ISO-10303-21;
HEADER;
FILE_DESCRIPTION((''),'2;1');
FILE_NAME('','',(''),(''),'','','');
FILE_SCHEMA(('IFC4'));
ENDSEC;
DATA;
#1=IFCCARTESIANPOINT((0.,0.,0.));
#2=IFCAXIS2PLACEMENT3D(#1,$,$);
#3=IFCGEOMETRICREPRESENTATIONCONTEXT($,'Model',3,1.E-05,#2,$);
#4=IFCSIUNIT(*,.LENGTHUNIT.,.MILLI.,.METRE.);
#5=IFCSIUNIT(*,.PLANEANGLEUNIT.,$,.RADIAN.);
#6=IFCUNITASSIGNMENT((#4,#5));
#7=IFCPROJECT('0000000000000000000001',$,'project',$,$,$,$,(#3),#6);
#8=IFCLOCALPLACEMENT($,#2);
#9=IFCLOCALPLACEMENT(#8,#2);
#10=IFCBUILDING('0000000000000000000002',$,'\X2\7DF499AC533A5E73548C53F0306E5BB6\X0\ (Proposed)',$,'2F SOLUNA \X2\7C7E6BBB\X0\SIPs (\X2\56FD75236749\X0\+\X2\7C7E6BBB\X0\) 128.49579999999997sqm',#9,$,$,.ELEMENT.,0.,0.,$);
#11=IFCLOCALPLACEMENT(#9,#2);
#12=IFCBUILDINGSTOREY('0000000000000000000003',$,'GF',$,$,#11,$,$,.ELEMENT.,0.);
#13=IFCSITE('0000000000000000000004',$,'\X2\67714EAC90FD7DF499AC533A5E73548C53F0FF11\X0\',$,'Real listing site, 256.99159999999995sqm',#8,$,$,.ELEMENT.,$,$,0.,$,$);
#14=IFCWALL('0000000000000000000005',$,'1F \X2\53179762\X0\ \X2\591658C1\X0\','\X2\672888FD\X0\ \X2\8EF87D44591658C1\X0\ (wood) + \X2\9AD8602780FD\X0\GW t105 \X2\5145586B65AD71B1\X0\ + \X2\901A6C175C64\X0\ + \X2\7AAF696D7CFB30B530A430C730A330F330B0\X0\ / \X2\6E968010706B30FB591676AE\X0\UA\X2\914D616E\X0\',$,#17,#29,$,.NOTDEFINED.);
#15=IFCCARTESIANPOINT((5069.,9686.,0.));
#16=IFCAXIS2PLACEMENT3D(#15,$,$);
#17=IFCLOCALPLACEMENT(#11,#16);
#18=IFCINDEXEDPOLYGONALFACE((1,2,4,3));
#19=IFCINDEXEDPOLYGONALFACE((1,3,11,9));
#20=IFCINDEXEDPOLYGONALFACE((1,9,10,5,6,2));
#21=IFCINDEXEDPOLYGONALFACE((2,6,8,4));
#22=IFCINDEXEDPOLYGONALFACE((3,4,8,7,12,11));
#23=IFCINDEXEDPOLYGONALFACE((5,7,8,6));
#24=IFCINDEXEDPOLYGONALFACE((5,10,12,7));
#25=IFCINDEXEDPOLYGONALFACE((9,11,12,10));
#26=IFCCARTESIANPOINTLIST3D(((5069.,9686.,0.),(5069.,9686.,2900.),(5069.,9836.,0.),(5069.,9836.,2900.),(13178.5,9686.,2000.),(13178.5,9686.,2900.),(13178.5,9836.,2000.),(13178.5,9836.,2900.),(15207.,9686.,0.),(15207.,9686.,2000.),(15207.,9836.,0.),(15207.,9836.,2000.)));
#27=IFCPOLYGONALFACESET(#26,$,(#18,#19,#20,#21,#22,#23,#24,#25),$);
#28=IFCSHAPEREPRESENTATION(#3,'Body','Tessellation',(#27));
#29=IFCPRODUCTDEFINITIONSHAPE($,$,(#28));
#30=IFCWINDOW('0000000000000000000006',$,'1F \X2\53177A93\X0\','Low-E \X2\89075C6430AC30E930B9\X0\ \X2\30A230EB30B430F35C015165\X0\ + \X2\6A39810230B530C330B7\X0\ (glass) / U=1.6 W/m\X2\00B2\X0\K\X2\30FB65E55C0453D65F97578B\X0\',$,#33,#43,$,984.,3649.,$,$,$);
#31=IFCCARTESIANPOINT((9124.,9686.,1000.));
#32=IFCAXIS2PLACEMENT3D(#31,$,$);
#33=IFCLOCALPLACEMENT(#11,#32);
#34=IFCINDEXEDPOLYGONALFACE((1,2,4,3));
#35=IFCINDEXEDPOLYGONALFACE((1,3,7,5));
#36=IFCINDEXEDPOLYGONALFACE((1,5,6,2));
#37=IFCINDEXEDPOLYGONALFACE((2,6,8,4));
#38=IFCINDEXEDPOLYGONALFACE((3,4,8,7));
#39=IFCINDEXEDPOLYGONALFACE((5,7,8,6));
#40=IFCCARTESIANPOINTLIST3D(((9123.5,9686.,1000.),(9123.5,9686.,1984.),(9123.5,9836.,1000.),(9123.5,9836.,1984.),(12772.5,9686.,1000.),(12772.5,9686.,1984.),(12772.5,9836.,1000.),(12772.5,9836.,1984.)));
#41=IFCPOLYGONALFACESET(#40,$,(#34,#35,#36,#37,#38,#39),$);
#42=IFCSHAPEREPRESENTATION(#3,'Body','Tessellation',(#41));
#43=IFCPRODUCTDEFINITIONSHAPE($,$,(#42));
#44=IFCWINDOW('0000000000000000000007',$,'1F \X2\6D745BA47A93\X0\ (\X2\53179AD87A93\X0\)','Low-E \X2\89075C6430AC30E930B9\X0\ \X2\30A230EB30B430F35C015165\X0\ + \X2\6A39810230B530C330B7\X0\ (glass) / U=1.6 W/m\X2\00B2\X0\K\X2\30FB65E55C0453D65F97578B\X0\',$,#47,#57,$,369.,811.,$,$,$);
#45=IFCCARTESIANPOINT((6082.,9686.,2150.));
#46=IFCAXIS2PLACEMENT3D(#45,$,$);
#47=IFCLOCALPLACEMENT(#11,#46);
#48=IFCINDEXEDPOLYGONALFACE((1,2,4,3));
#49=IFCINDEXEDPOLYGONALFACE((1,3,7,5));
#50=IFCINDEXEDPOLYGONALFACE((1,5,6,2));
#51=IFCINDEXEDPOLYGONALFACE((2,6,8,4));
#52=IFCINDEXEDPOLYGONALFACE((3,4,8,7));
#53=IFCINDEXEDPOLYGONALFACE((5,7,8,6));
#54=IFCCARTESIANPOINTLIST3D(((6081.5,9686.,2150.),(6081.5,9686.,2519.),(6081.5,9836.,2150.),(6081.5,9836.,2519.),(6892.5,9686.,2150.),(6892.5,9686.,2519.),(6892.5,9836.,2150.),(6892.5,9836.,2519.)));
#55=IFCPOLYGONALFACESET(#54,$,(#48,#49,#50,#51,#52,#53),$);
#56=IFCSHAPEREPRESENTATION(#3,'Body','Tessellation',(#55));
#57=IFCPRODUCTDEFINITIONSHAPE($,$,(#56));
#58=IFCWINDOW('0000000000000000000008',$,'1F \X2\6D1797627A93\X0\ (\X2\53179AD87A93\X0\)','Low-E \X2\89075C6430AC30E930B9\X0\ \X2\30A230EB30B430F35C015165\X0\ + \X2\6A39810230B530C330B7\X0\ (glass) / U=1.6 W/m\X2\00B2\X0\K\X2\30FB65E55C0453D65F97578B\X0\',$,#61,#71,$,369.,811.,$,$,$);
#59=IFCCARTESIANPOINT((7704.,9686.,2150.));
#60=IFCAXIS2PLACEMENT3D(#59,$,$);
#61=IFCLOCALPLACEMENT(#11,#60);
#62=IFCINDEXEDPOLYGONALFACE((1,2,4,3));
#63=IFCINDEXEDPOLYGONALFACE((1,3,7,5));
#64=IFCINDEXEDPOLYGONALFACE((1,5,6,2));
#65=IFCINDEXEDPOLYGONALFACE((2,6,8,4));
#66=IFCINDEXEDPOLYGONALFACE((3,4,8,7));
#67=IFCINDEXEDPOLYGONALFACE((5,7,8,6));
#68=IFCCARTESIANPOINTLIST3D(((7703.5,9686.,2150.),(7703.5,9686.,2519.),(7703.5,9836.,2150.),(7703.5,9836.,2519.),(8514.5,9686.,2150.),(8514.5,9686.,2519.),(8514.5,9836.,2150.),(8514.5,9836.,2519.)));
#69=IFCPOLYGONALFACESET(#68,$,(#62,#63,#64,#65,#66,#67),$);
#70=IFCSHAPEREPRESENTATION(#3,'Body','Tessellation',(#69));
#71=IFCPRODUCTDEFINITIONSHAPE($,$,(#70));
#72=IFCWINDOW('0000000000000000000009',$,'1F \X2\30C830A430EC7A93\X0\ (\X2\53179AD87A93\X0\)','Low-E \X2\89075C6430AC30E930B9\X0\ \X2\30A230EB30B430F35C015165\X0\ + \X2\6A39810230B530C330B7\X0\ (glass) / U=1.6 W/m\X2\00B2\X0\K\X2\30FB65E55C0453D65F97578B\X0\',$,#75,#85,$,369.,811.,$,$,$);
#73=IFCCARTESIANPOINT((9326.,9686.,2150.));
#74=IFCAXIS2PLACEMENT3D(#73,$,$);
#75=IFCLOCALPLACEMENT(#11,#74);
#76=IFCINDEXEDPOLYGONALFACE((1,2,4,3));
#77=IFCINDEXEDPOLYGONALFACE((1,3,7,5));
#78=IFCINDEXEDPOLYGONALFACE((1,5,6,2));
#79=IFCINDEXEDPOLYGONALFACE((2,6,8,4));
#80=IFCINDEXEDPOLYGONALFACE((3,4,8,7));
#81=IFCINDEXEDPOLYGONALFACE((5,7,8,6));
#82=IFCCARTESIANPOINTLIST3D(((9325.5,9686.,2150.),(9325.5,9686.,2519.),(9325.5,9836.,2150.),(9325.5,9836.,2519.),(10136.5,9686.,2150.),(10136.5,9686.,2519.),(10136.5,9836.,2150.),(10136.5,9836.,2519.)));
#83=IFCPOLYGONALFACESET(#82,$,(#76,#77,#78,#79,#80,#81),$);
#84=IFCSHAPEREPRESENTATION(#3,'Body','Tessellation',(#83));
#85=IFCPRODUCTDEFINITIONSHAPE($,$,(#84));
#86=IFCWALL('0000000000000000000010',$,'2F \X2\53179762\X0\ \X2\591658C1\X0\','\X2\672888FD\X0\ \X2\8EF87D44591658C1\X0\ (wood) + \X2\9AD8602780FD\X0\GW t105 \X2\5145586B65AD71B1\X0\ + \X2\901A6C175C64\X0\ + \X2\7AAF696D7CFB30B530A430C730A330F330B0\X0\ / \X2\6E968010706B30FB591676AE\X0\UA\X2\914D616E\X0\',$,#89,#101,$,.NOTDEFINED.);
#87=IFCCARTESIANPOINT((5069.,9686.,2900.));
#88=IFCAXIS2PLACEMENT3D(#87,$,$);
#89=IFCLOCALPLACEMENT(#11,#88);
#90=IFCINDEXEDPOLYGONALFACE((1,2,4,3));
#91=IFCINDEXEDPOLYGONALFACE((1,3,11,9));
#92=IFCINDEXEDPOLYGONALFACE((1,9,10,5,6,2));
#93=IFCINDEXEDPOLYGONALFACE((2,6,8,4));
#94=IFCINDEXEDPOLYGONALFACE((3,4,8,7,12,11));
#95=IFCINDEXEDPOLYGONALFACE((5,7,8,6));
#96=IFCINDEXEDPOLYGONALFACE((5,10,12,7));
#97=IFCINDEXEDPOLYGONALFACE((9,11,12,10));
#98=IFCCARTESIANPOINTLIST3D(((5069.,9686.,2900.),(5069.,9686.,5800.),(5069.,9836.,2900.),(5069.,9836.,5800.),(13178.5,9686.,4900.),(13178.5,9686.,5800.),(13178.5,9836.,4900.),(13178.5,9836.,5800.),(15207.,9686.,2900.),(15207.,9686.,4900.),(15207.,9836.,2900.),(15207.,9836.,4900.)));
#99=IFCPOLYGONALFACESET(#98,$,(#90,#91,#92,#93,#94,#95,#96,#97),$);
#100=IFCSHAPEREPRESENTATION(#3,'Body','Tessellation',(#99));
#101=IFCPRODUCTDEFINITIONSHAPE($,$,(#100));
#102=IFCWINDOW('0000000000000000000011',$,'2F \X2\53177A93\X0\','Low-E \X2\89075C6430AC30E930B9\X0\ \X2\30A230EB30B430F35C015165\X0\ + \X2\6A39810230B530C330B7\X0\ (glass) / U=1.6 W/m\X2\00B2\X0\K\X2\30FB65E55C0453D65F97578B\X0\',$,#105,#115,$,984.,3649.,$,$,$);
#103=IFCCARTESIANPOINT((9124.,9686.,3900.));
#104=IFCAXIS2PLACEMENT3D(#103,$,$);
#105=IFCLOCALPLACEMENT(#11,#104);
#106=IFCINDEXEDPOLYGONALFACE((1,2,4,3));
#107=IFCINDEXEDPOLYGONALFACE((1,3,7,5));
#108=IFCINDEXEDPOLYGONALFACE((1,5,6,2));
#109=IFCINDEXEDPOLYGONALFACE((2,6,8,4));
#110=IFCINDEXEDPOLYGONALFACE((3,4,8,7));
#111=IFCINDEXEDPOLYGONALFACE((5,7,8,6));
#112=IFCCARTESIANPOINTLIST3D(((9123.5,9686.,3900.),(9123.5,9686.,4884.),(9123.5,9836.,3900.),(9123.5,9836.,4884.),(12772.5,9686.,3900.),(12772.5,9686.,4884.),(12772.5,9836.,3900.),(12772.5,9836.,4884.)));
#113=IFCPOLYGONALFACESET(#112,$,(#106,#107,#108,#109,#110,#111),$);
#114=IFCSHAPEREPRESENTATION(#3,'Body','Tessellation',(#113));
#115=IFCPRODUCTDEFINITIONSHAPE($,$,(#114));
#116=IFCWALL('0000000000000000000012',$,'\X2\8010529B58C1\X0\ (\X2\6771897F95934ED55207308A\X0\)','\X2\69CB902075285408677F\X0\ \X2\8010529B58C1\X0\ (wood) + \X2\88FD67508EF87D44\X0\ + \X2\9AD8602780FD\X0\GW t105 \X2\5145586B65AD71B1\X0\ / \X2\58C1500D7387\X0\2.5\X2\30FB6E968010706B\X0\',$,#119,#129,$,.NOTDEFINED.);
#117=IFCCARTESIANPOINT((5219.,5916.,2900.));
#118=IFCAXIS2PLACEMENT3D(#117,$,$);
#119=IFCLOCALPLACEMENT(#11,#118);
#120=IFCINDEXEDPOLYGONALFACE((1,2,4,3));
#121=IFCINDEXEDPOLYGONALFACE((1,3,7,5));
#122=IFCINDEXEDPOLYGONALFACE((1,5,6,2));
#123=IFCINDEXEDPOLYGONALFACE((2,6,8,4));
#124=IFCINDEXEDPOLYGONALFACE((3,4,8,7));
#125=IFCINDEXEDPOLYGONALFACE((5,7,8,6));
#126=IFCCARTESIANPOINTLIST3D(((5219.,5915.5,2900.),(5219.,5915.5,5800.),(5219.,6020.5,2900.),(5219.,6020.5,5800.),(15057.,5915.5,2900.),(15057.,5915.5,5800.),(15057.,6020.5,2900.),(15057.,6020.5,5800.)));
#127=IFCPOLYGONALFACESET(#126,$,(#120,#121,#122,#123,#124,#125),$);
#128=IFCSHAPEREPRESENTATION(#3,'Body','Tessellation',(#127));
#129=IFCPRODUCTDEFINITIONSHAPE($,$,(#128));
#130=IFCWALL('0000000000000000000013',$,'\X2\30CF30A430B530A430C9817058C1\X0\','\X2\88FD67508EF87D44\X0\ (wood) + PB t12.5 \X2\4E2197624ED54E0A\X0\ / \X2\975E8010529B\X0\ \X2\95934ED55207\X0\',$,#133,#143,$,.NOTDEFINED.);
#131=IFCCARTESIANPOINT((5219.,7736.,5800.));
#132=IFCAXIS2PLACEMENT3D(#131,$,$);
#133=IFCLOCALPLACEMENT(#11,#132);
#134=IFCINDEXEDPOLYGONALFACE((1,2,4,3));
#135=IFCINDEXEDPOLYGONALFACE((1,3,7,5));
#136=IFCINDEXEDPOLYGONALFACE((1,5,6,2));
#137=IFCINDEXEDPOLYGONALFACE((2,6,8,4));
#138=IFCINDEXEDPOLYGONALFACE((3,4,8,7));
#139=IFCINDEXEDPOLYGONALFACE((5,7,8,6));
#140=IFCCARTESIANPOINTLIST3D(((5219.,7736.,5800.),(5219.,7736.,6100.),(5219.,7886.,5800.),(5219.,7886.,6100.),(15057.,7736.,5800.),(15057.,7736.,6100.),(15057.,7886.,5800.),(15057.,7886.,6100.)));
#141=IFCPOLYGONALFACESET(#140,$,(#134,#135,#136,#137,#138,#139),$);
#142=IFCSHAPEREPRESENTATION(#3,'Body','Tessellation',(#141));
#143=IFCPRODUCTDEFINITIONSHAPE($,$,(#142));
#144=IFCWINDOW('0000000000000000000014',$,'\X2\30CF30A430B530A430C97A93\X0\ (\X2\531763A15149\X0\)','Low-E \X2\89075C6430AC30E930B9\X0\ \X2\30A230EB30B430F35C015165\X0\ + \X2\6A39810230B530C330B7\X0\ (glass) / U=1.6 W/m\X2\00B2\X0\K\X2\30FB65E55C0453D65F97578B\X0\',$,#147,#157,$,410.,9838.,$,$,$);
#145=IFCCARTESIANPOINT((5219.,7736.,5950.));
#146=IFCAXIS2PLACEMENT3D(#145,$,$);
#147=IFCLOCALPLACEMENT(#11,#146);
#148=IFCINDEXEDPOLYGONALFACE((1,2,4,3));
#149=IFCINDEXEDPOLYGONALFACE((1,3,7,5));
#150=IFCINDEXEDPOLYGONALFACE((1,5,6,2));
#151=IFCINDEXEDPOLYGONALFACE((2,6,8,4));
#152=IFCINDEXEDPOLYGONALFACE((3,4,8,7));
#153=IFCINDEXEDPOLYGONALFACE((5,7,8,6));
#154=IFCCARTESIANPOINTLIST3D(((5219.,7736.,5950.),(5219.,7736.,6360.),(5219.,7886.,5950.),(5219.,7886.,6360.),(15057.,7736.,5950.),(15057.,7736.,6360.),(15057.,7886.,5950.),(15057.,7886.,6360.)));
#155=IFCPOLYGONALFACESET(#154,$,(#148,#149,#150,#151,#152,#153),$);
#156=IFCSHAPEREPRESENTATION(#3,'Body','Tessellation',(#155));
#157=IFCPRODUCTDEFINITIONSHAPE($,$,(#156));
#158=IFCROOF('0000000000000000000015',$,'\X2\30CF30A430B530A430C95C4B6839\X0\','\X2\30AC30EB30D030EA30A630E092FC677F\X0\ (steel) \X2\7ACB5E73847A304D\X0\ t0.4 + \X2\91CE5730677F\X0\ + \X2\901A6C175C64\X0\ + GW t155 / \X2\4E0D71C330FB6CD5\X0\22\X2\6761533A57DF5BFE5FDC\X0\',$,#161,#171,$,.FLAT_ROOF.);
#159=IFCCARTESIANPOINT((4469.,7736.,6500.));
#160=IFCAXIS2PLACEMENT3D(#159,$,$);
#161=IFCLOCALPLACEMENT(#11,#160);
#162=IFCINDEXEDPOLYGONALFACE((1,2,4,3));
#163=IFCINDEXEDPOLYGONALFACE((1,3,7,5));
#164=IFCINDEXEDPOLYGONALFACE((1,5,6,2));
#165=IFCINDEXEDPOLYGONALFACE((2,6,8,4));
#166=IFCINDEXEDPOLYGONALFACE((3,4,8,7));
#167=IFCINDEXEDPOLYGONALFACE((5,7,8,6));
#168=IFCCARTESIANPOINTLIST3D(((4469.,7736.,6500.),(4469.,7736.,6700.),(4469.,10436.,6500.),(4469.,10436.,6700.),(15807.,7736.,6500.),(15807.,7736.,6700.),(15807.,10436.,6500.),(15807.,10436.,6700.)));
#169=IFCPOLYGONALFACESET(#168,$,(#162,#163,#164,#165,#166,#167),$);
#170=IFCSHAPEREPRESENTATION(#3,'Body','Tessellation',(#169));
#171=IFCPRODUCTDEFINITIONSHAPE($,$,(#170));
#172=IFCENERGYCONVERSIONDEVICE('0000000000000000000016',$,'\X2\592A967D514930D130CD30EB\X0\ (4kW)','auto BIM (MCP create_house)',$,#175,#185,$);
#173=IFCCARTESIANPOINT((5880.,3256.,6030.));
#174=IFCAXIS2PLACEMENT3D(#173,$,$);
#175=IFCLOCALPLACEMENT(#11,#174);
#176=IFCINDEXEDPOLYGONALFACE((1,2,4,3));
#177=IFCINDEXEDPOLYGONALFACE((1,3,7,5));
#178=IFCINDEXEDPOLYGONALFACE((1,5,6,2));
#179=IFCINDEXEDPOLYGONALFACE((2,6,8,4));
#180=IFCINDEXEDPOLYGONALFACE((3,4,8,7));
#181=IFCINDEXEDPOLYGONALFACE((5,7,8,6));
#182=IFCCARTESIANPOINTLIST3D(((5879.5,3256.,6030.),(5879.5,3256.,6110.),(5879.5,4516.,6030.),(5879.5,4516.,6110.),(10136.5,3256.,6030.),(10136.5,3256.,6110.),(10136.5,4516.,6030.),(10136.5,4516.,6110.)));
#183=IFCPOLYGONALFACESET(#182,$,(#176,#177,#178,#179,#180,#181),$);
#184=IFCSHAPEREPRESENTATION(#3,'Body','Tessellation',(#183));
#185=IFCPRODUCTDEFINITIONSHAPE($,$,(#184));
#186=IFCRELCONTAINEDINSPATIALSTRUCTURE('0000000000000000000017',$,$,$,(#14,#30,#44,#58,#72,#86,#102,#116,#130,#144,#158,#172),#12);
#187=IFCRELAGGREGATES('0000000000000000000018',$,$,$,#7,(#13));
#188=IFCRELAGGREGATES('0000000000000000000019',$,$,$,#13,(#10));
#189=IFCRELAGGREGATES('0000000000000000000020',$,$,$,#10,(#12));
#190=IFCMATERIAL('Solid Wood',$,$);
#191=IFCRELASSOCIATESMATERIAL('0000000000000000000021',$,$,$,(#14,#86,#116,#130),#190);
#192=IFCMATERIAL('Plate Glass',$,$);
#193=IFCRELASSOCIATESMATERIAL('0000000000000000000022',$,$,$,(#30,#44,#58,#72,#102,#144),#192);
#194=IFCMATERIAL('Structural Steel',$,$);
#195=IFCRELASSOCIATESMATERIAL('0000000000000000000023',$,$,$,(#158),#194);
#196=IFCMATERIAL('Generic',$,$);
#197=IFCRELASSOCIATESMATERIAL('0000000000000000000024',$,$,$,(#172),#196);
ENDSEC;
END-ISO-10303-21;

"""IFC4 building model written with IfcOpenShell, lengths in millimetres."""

from ifc_helpers import new_model, si_unit, frame, frame_2d, origin, place, context, project, spatial, rectangle, extrude, material, element, fill, save


model = new_model("IFC4")

# Units and contexts
model_context = context("Model", 3, precision=1e-05, world=origin())
ifc_project = project(units=[si_unit("LENGTHUNIT", "METRE", prefix="MILLI"), si_unit("PLANEANGLEUNIT", "RADIAN")], contexts=[model_context])

# Site, building, storey
site_placement = place(None, origin())
site = spatial("IfcSite", under=ifc_project, at=site_placement, Name="東京都練馬区平和台１", ObjectType="Real listing site, 256.99159999999995sqm", CompositionType="ELEMENT", RefElevation=0.0)
building_placement = place(site_placement, origin())
building = spatial("IfcBuilding", under=site, at=building_placement, Name="練馬区平和台の家 (Proposed)", ObjectType="2F SOLUNA 籾殻SIPs (国産杉+籾殻) 128.49579999999997sqm", CompositionType="ELEMENT", ElevationOfRefHeight=0.0, ElevationOfTerrain=0.0)
storey_placement = place(building_placement, origin())
storey = spatial("IfcBuildingStorey", under=building, at=storey_placement, Name="GF", CompositionType="ELEMENT", Elevation=0.0)

# Wall, openings, windows
ifc_material_1 = material(Name="Solid Wood")
wall_1_placement = place(storey_placement, frame((5069.0, 9686.0, 0.0)))
wall_1 = element("IfcWall", 1, at=wall_1_placement, inside=storey, material=ifc_material_1, Name="1F 北面 外壁", Description="木製 軸組外壁 (wood) + 高性能GW t105 充填断熱 + 通気層 + 窯業系サイディング / 準耐火・外皮UA配慮", PredefinedType="NOTDEFINED", context=model_context, shape_type="SweptSolid", body=[
    extrude(rectangle(XDim=10138.0, YDim=150.0, at=frame_2d((5069.0, 75.0))), frame((5069.0, 9686.0, 0.0)), (0.0, 0.0, 1.0), 2900.0),
])
opening_1_placement = place(storey_placement, frame((9124.0, 9686.0, 1000.0)))
opening_1 = element("IfcOpeningElement", 2, at=opening_1_placement, cuts=wall_1, PredefinedType="NOTDEFINED", context=model_context, shape_type="SweptSolid", body=[
    extrude(rectangle(XDim=3649.0, YDim=150.0, at=frame_2d((1824.0, 75.0))), frame((9124.0, 9686.0, 1000.0)), (0.0, 0.0, 1.0), 984.0),
])
opening_2_placement = place(storey_placement, frame((6082.0, 9686.0, 2150.0)))
opening_2 = element("IfcOpeningElement", 3, at=opening_2_placement, cuts=wall_1, PredefinedType="NOTDEFINED", context=model_context, shape_type="SweptSolid", body=[
    extrude(rectangle(XDim=811.0, YDim=150.0, at=frame_2d((405.0, 75.0))), frame((6082.0, 9686.0, 2150.0)), (0.0, 0.0, 1.0), 369.0),
])
opening_3_placement = place(storey_placement, frame((7704.0, 9686.0, 2150.0)))
opening_3 = element("IfcOpeningElement", 4, at=opening_3_placement, cuts=wall_1, PredefinedType="NOTDEFINED", context=model_context, shape_type="SweptSolid", body=[
    extrude(rectangle(XDim=811.0, YDim=150.0, at=frame_2d((405.0, 75.0))), frame((7704.0, 9686.0, 2150.0)), (0.0, 0.0, 1.0), 369.0),
])
opening_4_placement = place(storey_placement, frame((9326.0, 9686.0, 2150.0)))
opening_4 = element("IfcOpeningElement", 5, at=opening_4_placement, cuts=wall_1, PredefinedType="NOTDEFINED", context=model_context, shape_type="SweptSolid", body=[
    extrude(rectangle(XDim=811.0, YDim=150.0, at=frame_2d((405.0, 75.0))), frame((9326.0, 9686.0, 2150.0)), (0.0, 0.0, 1.0), 369.0),
])
ifc_material_2 = material(Name="Plate Glass")
window_1_placement = place(storey_placement, frame((9124.0, 9686.0, 1000.0)))
window_1 = element("IfcWindow", 6, at=window_1_placement, inside=storey, material=ifc_material_2, Name="1F 北窓", Description="Low-E 複層ガラス アルゴン封入 + 樹脂サッシ (glass) / U=1.6 W/m²K・日射取得型", OverallHeight=984.0, OverallWidth=3649.0, context=model_context, shape_type="SweptSolid", body=[
    extrude(rectangle(XDim=3649.0, YDim=150.0, at=frame_2d((1824.0, 75.0))), frame((9124.0, 9686.0, 1000.0)), (0.0, 0.0, 1.0), 984.0),
])
fill(opening_1, window_1)
window_2_placement = place(storey_placement, frame((6082.0, 9686.0, 2150.0)))
window_2 = element("IfcWindow", 7, at=window_2_placement, inside=storey, material=ifc_material_2, Name="1F 浴室窓 (北高窓)", Description="Low-E 複層ガラス アルゴン封入 + 樹脂サッシ (glass) / U=1.6 W/m²K・日射取得型", OverallHeight=369.0, OverallWidth=811.0, context=model_context, shape_type="SweptSolid", body=[
    extrude(rectangle(XDim=811.0, YDim=150.0, at=frame_2d((405.0, 75.0))), frame((6082.0, 9686.0, 2150.0)), (0.0, 0.0, 1.0), 369.0),
])
fill(opening_2, window_2)
window_3_placement = place(storey_placement, frame((7704.0, 9686.0, 2150.0)))
window_3 = element("IfcWindow", 8, at=window_3_placement, inside=storey, material=ifc_material_2, Name="1F 洗面窓 (北高窓)", Description="Low-E 複層ガラス アルゴン封入 + 樹脂サッシ (glass) / U=1.6 W/m²K・日射取得型", OverallHeight=369.0, OverallWidth=811.0, context=model_context, shape_type="SweptSolid", body=[
    extrude(rectangle(XDim=811.0, YDim=150.0, at=frame_2d((405.0, 75.0))), frame((7704.0, 9686.0, 2150.0)), (0.0, 0.0, 1.0), 369.0),
])
fill(opening_3, window_3)
window_4_placement = place(storey_placement, frame((9326.0, 9686.0, 2150.0)))
window_4 = element("IfcWindow", 9, at=window_4_placement, inside=storey, material=ifc_material_2, Name="1F トイレ窓 (北高窓)", Description="Low-E 複層ガラス アルゴン封入 + 樹脂サッシ (glass) / U=1.6 W/m²K・日射取得型", OverallHeight=369.0, OverallWidth=811.0, context=model_context, shape_type="SweptSolid", body=[
    extrude(rectangle(XDim=811.0, YDim=150.0, at=frame_2d((405.0, 75.0))), frame((9326.0, 9686.0, 2150.0)), (0.0, 0.0, 1.0), 369.0),
])
fill(opening_4, window_4)

# Wall, opening, window
wall_2_placement = place(storey_placement, frame((5069.0, 9686.0, 2900.0)))
wall_2 = element("IfcWall", 10, at=wall_2_placement, inside=storey, material=ifc_material_1, Name="2F 北面 外壁", Description="木製 軸組外壁 (wood) + 高性能GW t105 充填断熱 + 通気層 + 窯業系サイディング / 準耐火・外皮UA配慮", PredefinedType="NOTDEFINED", context=model_context, shape_type="SweptSolid", body=[
    extrude(rectangle(XDim=10138.0, YDim=150.0, at=frame_2d((5069.0, 75.0))), frame((5069.0, 9686.0, 2900.0)), (0.0, 0.0, 1.0), 2900.0),
])
opening_5_placement = place(storey_placement, frame((9124.0, 9686.0, 3900.0)))
opening_5 = element("IfcOpeningElement", 11, at=opening_5_placement, cuts=wall_2, PredefinedType="NOTDEFINED", context=model_context, shape_type="SweptSolid", body=[
    extrude(rectangle(XDim=3649.0, YDim=150.0, at=frame_2d((1824.0, 75.0))), frame((9124.0, 9686.0, 3900.0)), (0.0, 0.0, 1.0), 984.0),
])
window_5_placement = place(storey_placement, frame((9124.0, 9686.0, 3900.0)))
window_5 = element("IfcWindow", 12, at=window_5_placement, inside=storey, material=ifc_material_2, Name="2F 北窓", Description="Low-E 複層ガラス アルゴン封入 + 樹脂サッシ (glass) / U=1.6 W/m²K・日射取得型", OverallHeight=984.0, OverallWidth=3649.0, context=model_context, shape_type="SweptSolid", body=[
    extrude(rectangle(XDim=3649.0, YDim=150.0, at=frame_2d((1824.0, 75.0))), frame((9124.0, 9686.0, 3900.0)), (0.0, 0.0, 1.0), 984.0),
])
fill(opening_5, window_5)

# Wall
wall_3_placement = place(storey_placement, frame((5219.0, 5916.0, 2900.0)))
element("IfcWall", 13, at=wall_3_placement, inside=storey, material=ifc_material_1, Name="耐力壁 (東西間仕切り)", Description="構造用合板 耐力壁 (wood) + 製材軸組 + 高性能GW t105 充填断熱 / 壁倍率2.5・準耐火", PredefinedType="NOTDEFINED", context=model_context, shape_type="SweptSolid", body=[
    extrude(rectangle(XDim=9838.0, YDim=105.0, at=frame_2d((4919.0, 52.0))), frame((5219.0, 5916.0, 2900.0)), (0.0, 0.0, 1.0), 2900.0),
])

# Wall, opening, window
wall_4_placement = place(storey_placement, frame((5219.0, 7736.0, 5800.0)))
wall_4 = element("IfcWall", 14, at=wall_4_placement, inside=storey, material=ifc_material_1, Name="ハイサイド腰壁", Description="製材軸組 (wood) + PB t12.5 両面仕上 / 非耐力 間仕切", PredefinedType="NOTDEFINED", context=model_context, shape_type="SweptSolid", body=[
    extrude(rectangle(XDim=9838.0, YDim=150.0, at=frame_2d((4919.0, 75.0))), frame((5219.0, 7736.0, 5800.0)), (0.0, 0.0, 1.0), 700.0),
])
opening_6_placement = place(storey_placement, frame((5219.0, 7736.0, 5950.0)))
opening_6 = element("IfcOpeningElement", 15, at=opening_6_placement, cuts=wall_4, PredefinedType="NOTDEFINED", context=model_context, shape_type="SweptSolid", body=[
    extrude(rectangle(XDim=9838.0, YDim=150.0, at=frame_2d((4919.0, 75.0))), frame((5219.0, 7736.0, 5950.0)), (0.0, 0.0, 1.0), 410.0),
])
window_6_placement = place(storey_placement, frame((5219.0, 7736.0, 5950.0)))
window_6 = element("IfcWindow", 16, at=window_6_placement, inside=storey, material=ifc_material_2, Name="ハイサイド窓 (北採光)", Description="Low-E 複層ガラス アルゴン封入 + 樹脂サッシ (glass) / U=1.6 W/m²K・日射取得型", OverallHeight=410.0, OverallWidth=9838.0, context=model_context, shape_type="SweptSolid", body=[
    extrude(rectangle(XDim=9838.0, YDim=150.0, at=frame_2d((4919.0, 75.0))), frame((5219.0, 7736.0, 5950.0)), (0.0, 0.0, 1.0), 410.0),
])
fill(opening_6, window_6)

# Roof
ifc_material_3 = material(Name="Structural Steel")
roof_placement = place(storey_placement, frame((4469.0, 7736.0, 6500.0)))
element("IfcRoof", 17, at=roof_placement, inside=storey, material=ifc_material_3, Name="ハイサイド屋根", Description="ガルバリウム鋼板 (steel) 立平葺き t0.4 + 野地板 + 通気層 + GW t155 / 不燃・法22条区域対応", PredefinedType="FLAT_ROOF", context=model_context, shape_type="SweptSolid", body=[
    extrude(rectangle(XDim=11338.0, YDim=2700.0, at=frame_2d((5669.0, 1350.0))), frame((4469.0, 7736.0, 6500.0)), (0.0, 0.0, 1.0), 200.0),
])

# Energy conversion device
ifc_material_4 = material(Name="Generic")
energy_conversion_device_placement = place(storey_placement, frame((5880.0, 3256.0, 6030.0)))
element("IfcEnergyConversionDevice", 18, at=energy_conversion_device_placement, inside=storey, material=ifc_material_4, Name="太陽光パネル (4kW)", Description="auto BIM (MCP create_house)", context=model_context, shape_type="SweptSolid", body=[
    extrude(rectangle(XDim=4257.0, YDim=1260.0, at=frame_2d((2128.0, 630.0))), frame((5880.0, 3256.0, 6030.0)), (0.0, 0.0, 1.0), 80.0),
])

save(model, "model.ifc")
